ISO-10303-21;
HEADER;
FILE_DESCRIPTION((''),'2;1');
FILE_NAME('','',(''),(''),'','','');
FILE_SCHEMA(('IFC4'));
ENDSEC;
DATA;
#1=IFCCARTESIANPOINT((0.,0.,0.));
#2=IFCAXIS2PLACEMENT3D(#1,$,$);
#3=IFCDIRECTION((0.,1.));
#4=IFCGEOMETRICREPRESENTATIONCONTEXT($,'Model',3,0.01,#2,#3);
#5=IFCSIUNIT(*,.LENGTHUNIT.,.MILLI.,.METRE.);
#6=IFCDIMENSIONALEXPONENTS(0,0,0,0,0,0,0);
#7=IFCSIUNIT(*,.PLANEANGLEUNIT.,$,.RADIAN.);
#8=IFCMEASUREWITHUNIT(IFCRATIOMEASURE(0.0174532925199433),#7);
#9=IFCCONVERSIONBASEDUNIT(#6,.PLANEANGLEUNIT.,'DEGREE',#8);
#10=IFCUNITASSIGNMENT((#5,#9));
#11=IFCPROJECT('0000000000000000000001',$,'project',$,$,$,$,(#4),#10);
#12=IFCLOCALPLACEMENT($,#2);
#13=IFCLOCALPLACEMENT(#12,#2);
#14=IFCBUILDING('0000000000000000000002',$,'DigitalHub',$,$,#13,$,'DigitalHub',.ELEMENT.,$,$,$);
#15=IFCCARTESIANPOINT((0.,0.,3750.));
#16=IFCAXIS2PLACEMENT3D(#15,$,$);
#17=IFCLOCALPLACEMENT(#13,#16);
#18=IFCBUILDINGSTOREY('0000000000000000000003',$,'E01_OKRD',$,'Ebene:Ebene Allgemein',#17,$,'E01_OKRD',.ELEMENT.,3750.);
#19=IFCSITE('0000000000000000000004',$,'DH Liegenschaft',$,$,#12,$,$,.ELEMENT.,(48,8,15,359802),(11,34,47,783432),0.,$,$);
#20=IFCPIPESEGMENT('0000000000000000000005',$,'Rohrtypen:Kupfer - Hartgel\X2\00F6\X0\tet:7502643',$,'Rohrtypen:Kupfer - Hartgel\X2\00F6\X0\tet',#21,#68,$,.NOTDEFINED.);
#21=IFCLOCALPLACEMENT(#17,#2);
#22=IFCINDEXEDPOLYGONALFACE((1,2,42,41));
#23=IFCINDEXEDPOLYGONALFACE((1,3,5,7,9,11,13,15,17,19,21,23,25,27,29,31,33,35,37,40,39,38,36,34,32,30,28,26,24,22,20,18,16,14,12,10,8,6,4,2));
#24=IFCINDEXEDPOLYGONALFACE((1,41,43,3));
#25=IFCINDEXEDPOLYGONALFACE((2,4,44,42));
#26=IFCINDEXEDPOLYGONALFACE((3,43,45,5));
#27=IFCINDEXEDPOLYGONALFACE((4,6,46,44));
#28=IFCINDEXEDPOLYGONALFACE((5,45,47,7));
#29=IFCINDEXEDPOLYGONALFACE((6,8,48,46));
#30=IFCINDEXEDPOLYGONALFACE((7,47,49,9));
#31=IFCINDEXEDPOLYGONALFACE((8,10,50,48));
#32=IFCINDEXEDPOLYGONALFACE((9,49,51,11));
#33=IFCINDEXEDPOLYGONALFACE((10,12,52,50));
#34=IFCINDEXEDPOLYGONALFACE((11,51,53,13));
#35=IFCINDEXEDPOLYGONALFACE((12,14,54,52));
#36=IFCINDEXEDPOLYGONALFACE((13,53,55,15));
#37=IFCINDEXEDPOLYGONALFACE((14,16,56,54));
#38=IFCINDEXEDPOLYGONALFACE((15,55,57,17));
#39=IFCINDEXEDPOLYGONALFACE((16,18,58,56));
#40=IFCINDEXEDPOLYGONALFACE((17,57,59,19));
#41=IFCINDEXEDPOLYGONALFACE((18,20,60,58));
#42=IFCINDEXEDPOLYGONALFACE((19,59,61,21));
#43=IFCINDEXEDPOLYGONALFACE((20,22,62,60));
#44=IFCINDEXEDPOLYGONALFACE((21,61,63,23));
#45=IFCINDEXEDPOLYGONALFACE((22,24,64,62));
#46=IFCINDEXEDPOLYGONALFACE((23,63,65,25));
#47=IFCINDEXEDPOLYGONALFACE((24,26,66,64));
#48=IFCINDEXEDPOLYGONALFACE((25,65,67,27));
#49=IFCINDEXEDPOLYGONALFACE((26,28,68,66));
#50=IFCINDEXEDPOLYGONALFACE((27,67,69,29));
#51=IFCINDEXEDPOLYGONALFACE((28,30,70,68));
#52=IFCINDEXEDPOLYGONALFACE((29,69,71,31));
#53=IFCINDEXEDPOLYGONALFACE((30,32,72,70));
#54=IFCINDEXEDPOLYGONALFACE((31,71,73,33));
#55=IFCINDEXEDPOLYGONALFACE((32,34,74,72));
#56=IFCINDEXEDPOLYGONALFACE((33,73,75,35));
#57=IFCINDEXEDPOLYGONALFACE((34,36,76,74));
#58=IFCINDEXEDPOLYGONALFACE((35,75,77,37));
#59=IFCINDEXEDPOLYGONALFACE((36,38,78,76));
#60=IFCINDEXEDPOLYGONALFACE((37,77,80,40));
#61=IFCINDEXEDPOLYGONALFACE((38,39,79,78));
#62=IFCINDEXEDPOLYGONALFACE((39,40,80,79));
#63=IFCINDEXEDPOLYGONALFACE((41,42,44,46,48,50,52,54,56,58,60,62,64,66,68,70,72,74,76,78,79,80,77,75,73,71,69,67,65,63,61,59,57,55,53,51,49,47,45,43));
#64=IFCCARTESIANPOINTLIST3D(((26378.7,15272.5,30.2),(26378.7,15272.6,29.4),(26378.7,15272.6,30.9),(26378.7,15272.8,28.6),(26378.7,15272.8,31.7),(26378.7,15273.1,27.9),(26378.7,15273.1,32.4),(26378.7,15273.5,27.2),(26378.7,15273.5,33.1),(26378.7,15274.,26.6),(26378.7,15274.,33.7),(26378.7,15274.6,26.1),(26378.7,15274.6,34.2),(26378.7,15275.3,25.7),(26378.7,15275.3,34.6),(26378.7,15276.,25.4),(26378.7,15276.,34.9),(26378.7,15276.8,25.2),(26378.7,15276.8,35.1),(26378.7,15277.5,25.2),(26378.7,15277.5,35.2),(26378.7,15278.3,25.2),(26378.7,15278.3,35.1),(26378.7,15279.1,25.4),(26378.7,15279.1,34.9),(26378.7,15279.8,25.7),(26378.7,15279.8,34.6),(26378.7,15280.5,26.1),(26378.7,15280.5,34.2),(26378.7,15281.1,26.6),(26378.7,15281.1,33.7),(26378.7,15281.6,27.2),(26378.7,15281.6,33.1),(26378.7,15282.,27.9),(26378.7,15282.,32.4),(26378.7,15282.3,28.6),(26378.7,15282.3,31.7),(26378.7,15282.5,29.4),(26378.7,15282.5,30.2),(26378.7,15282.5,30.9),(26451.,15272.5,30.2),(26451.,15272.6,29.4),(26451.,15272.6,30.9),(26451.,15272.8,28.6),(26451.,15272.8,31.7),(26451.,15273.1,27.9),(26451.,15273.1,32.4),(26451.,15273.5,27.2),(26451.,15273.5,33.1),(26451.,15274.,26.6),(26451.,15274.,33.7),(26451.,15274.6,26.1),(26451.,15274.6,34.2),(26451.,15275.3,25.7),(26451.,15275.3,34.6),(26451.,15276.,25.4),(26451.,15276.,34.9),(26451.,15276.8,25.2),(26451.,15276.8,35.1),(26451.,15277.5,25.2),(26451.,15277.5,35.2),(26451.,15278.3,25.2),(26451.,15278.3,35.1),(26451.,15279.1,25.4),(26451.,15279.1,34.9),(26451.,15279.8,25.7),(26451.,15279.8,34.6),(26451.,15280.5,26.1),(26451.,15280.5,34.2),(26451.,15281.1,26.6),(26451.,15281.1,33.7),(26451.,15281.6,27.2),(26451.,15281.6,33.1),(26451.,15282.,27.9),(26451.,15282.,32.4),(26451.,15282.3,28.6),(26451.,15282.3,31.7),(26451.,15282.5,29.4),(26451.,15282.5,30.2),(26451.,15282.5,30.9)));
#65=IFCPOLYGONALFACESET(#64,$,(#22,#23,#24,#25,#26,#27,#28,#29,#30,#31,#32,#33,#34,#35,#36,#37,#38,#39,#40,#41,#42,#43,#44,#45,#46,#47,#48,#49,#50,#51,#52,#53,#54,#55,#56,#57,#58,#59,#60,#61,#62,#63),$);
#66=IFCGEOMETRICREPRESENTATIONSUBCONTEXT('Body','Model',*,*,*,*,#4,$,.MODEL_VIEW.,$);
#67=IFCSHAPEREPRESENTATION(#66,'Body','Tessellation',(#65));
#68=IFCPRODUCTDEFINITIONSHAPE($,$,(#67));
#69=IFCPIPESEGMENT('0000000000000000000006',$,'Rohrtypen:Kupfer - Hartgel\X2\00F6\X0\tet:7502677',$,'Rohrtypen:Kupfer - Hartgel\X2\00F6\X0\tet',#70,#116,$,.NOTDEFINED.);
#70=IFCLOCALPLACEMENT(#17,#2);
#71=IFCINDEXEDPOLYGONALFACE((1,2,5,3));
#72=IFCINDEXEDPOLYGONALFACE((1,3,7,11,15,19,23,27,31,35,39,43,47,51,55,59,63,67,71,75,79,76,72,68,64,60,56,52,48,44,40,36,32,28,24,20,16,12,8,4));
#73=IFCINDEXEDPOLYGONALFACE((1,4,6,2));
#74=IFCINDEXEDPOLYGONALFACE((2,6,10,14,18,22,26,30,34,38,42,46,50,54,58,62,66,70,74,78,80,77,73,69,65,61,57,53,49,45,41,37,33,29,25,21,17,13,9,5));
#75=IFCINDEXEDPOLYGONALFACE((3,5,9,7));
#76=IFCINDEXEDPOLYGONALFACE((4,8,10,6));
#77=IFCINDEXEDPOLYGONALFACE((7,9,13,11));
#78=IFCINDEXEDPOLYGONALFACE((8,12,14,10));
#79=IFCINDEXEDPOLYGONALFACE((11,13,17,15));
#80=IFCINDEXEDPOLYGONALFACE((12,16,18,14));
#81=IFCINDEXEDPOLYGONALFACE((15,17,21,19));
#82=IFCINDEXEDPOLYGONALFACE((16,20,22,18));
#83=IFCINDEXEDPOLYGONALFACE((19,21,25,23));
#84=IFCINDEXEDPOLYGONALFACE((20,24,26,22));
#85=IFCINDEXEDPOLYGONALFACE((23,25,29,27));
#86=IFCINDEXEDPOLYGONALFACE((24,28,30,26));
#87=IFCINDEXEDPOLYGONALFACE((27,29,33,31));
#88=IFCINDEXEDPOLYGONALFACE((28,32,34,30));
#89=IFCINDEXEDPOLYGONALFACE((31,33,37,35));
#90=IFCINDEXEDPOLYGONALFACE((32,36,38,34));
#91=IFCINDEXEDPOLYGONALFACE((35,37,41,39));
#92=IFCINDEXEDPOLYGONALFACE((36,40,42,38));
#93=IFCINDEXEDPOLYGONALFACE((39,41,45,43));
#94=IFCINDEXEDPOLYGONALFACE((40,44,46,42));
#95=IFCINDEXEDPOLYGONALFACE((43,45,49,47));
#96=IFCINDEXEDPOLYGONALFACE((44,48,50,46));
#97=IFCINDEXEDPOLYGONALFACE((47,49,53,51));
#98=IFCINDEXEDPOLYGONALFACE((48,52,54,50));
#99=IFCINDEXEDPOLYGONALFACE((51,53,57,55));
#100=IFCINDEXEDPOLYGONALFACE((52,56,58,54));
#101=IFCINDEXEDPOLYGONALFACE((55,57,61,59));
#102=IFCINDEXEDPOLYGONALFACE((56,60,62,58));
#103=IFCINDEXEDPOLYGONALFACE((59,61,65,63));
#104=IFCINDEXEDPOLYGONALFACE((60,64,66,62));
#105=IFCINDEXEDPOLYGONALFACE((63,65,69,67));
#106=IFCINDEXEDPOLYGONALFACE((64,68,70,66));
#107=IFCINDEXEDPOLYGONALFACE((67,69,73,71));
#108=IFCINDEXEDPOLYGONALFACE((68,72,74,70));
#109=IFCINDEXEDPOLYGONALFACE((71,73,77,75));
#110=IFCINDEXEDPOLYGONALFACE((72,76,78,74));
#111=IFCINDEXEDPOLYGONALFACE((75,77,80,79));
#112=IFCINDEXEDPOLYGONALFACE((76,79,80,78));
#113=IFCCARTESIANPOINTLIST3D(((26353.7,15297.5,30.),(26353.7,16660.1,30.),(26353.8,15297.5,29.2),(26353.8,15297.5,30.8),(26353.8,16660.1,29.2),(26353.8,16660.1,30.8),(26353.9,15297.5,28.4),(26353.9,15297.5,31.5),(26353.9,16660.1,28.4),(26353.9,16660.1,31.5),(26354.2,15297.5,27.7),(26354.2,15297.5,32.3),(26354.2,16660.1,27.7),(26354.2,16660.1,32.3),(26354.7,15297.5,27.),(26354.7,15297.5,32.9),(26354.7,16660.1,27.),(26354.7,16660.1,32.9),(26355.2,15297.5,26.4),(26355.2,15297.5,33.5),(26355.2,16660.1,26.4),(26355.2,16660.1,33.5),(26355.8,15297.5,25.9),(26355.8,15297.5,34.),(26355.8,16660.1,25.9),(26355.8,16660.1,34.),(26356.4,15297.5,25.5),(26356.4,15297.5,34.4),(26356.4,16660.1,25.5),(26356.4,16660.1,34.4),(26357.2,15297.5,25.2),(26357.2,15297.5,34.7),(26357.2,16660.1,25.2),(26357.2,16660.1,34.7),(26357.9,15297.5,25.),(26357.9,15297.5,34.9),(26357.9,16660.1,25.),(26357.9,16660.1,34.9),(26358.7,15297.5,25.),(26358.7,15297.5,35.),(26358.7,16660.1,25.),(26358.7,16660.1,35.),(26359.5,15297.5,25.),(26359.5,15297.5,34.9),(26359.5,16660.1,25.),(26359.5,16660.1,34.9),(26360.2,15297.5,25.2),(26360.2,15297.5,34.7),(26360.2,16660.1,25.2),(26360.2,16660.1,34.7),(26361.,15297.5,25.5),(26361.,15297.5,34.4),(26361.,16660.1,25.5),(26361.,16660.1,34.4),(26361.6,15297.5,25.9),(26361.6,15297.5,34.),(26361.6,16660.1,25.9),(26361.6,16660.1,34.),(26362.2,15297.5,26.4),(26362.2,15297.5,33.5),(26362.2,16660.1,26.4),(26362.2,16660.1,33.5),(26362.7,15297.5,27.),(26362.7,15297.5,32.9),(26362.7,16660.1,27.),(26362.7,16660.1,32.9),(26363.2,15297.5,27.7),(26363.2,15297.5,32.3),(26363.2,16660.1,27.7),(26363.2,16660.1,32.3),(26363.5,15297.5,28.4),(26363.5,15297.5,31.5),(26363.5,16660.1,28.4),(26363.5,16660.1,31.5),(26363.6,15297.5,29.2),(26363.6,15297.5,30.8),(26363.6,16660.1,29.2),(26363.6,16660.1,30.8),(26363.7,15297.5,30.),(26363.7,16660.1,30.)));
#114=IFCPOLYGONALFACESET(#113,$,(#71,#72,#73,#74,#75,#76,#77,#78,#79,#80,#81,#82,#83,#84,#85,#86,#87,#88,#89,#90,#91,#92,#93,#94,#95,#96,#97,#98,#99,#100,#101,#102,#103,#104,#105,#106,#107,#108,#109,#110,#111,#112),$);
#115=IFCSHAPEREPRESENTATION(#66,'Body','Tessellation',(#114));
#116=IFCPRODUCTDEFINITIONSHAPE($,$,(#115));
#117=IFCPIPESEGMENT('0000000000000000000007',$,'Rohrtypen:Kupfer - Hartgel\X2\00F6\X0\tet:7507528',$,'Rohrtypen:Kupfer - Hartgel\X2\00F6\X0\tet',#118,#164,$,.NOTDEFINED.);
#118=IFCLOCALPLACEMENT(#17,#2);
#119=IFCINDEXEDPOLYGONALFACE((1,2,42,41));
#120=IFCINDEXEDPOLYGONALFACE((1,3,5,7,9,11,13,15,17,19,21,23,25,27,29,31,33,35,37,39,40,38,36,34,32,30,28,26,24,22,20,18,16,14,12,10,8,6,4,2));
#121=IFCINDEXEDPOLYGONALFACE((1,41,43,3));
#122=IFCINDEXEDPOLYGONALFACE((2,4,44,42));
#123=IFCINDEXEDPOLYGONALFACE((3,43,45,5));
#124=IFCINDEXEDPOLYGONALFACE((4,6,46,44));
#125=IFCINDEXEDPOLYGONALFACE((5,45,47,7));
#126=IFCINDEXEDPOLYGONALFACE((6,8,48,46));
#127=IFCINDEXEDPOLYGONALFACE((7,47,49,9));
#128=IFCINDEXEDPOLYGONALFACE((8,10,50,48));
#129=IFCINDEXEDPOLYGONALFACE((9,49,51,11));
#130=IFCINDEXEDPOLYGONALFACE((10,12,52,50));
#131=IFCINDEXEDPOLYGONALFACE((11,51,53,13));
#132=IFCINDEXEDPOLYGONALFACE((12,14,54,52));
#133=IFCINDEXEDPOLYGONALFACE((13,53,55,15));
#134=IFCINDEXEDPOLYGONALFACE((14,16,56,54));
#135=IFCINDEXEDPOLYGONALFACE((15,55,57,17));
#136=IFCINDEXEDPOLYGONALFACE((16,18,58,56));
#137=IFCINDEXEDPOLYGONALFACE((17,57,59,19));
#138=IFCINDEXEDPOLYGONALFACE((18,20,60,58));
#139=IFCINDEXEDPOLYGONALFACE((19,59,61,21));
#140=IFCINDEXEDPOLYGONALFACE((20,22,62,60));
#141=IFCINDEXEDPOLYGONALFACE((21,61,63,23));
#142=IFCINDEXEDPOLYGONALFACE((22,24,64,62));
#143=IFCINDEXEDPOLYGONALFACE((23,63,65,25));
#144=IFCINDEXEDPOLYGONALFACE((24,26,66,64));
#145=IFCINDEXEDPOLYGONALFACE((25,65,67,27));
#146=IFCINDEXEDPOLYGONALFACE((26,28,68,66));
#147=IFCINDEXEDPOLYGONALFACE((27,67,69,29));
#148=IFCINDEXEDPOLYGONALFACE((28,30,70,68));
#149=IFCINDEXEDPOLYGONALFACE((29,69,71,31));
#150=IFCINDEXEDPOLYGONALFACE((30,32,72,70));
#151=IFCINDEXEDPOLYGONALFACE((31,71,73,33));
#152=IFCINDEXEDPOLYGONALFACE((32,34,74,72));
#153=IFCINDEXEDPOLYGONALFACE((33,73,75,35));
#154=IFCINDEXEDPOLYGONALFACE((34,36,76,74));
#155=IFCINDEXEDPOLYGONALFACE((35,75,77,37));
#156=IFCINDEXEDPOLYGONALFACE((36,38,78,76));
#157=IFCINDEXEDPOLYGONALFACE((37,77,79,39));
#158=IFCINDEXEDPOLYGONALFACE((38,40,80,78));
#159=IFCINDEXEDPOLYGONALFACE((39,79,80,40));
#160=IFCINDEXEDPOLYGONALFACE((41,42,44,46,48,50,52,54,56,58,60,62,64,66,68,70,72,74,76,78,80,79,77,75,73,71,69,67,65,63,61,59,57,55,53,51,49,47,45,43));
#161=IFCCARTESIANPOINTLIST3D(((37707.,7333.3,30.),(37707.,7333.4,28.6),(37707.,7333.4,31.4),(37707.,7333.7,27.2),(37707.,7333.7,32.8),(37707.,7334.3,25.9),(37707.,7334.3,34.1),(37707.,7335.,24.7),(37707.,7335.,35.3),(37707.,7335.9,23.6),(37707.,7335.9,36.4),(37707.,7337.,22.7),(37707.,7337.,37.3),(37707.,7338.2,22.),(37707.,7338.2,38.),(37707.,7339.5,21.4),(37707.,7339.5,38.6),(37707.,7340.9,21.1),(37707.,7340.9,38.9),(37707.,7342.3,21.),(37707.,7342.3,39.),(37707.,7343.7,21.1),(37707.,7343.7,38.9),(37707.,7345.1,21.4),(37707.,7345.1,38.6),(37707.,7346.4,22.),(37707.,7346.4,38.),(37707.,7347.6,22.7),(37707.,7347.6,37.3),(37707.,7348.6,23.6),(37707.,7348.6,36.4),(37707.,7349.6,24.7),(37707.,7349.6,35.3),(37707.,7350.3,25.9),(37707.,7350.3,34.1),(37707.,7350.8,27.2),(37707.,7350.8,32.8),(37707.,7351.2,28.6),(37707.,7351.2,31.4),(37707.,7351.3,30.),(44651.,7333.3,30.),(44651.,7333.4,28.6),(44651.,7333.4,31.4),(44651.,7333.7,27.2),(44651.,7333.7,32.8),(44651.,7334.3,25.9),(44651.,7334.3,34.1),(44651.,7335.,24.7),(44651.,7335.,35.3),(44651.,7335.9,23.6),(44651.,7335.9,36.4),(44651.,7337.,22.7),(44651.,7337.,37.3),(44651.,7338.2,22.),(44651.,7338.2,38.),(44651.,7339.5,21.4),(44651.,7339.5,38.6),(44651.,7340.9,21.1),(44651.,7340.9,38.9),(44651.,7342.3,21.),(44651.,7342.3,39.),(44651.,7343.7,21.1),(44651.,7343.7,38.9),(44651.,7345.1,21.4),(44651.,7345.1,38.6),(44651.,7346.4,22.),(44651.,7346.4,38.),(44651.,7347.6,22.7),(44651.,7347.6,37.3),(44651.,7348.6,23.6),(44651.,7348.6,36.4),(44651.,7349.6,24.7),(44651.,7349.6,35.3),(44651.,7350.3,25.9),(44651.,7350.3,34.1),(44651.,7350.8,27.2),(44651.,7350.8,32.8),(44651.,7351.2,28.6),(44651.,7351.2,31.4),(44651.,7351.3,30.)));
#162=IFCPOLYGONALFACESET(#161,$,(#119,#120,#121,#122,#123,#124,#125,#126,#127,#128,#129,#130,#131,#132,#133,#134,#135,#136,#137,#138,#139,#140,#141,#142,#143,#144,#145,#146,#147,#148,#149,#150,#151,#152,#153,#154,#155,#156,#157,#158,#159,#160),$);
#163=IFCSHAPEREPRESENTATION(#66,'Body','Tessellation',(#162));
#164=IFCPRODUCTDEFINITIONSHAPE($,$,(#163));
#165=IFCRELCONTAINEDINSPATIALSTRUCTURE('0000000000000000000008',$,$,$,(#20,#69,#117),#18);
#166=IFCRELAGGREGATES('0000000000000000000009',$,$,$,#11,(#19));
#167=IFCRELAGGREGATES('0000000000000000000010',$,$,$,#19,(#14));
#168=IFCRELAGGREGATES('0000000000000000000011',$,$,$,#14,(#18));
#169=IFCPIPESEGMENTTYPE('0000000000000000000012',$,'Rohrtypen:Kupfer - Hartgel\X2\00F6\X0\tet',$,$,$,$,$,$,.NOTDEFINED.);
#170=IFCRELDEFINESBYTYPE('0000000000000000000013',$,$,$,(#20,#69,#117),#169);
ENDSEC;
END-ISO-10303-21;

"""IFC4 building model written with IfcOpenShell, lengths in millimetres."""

from ifc_helpers import new_model, entity, si_unit, converted_unit, direction, frame, origin, place, context, subcontext, project, spatial, indexed_curve, outline, extrude, type_object, element, save


model = new_model("IFC4")

# Units and contexts
model_context = context("Model", 3, precision=0.01, world=origin(), true_north=direction((0.0, 1.0)))
body_context = subcontext(model_context, "Body", "Model", "MODEL_VIEW")
ifc_project = project(units=[si_unit("LENGTHUNIT", "METRE", prefix="MILLI"), converted_unit("PLANEANGLEUNIT", "DEGREE", entity("IfcRatioMeasure", 0.0174532925199433), si_unit("PLANEANGLEUNIT", "RADIAN"), dimensions=[0, 0, 0, 0, 0, 0, 0])], contexts=[model_context])

# Site, building, storey
site_placement = place(None, origin())
site = spatial("IfcSite", under=ifc_project, at=site_placement, Name="DH Liegenschaft", CompositionType="ELEMENT", RefLatitude=(48, 8, 15, 359802), RefLongitude=(11, 34, 47, 783432), RefElevation=0.0)
building_placement = place(site_placement, origin())
building = spatial("IfcBuilding", under=site, at=building_placement, Name="DigitalHub", LongName="DigitalHub", CompositionType="ELEMENT")
storey_placement = place(building_placement, frame((0.0, 0.0, 3750.0)))
storey = spatial("IfcBuildingStorey", under=building, at=storey_placement, Name="E01_OKRD", ObjectType="Ebene:Ebene Allgemein", LongName="E01_OKRD", CompositionType="ELEMENT", Elevation=3750.0)

# Pipe segments
pipe_segment_type = type_object("IfcPipeSegmentType", Name="Rohrtypen:Kupfer - Hartgelötet", PredefinedType="NOTDEFINED")
pipe_segment_1_placement = place(storey_placement, frame((26378.7, 15270.9, 23.6)))
element("IfcPipeSegment", 1, at=pipe_segment_1_placement, inside=storey, type_object=pipe_segment_type, Name="Rohrtypen:Kupfer - Hartgelötet:7502643", ObjectType="Rohrtypen:Kupfer - Hartgelötet", PredefinedType="NOTDEFINED", context=body_context, shape_type="SweptSolid", body=[
    extrude(outline(indexed_curve([(5.0, 0.0), (4.9, 0.8), (4.8, 1.5), (4.5, 2.3), (4.0, 2.9), (3.5, 3.5), (2.9, 4.0), (2.3, 4.5), (1.5, 4.8), (0.8, 4.9), (0.0, 5.0), (-0.8, 4.9), (-1.5, 4.8), (-2.3, 4.5), (-2.9, 4.0), (-3.5, 3.5), (-4.0, 2.9), (-4.5, 2.3), (-4.8, 1.5), (-4.9, 0.8), (-5.0, 0.0), (-4.9, -0.8), (-4.8, -1.5), (-4.5, -2.3), (-4.0, -2.9), (-3.5, -3.5), (-2.9, -4.0), (-2.3, -4.5), (-1.5, -4.8), (-0.8, -4.9), (0.0, -5.0), (0.8, -4.9), (1.5, -4.8), (2.3, -4.5), (2.9, -4.0), (3.5, -3.5), (4.0, -2.9), (4.5, -2.3), (4.8, -1.5), (4.9, -0.8), (5.0, 0.0)], self_intersect=False)), frame((0.0, 6.6, 6.6), z_axis=(1.0, 0.0, 0.0), x_axis=(0.0, 1.0, 0.0)), (0.0, 0.0, 1.0), 72.2),
])
pipe_segment_2_placement = place(storey_placement, frame((26352.1, 15297.5, 23.4)))
element("IfcPipeSegment", 2, at=pipe_segment_2_placement, inside=storey, type_object=pipe_segment_type, Name="Rohrtypen:Kupfer - Hartgelötet:7502677", ObjectType="Rohrtypen:Kupfer - Hartgelötet", PredefinedType="NOTDEFINED", context=body_context, shape_type="SweptSolid", body=[
    extrude(outline(indexed_curve([(5.0, 0.0), (4.9, 0.8), (4.8, 1.5), (4.5, 2.3), (4.0, 2.9), (3.5, 3.5), (2.9, 4.0), (2.3, 4.5), (1.5, 4.8), (0.8, 4.9), (0.0, 5.0), (-0.8, 4.9), (-1.5, 4.8), (-2.3, 4.5), (-2.9, 4.0), (-3.5, 3.5), (-4.0, 2.9), (-4.5, 2.3), (-4.8, 1.5), (-4.9, 0.8), (-5.0, 0.0), (-4.9, -0.8), (-4.8, -1.5), (-4.5, -2.3), (-4.0, -2.9), (-3.5, -3.5), (-2.9, -4.0), (-2.3, -4.5), (-1.5, -4.8), (-0.8, -4.9), (0.0, -5.0), (0.8, -4.9), (1.5, -4.8), (2.3, -4.5), (2.9, -4.0), (3.5, -3.5), (4.0, -2.9), (4.5, -2.3), (4.8, -1.5), (4.9, -0.8), (5.0, 0.0)], self_intersect=False)), frame((6.6, 0.0, 6.6), z_axis=(0.0, 1.0, 0.0), x_axis=(-1.0, 0.0, 0.0)), (0.0, 0.0, 1.0), 1362.6),
])
pipe_segment_3_placement = place(storey_placement, frame((37707.0, 7331.7, 19.4)))
element("IfcPipeSegment", 3, at=pipe_segment_3_placement, inside=storey, type_object=pipe_segment_type, Name="Rohrtypen:Kupfer - Hartgelötet:7507528", ObjectType="Rohrtypen:Kupfer - Hartgelötet", PredefinedType="NOTDEFINED", context=body_context, shape_type="SweptSolid", body=[
    extrude(outline(indexed_curve([(9.0, 0.0), (8.9, 1.4), (8.6, 2.8), (8.0, 4.1), (7.3, 5.3), (6.4, 6.4), (5.3, 7.3), (4.1, 8.0), (2.8, 8.6), (1.4, 8.9), (0.0, 9.0), (-1.4, 8.9), (-2.8, 8.6), (-4.1, 8.0), (-5.3, 7.3), (-6.4, 6.4), (-7.3, 5.3), (-8.0, 4.1), (-8.6, 2.8), (-8.9, 1.4), (-9.0, 0.0), (-8.9, -1.4), (-8.6, -2.8), (-8.0, -4.1), (-7.3, -5.3), (-6.4, -6.4), (-5.3, -7.3), (-4.1, -8.0), (-2.8, -8.6), (-1.4, -8.9), (0.0, -9.0), (1.4, -8.9), (2.8, -8.6), (4.1, -8.0), (5.3, -7.3), (6.4, -6.4), (7.3, -5.3), (8.0, -4.1), (8.6, -2.8), (8.9, -1.4), (9.0, 0.0)], self_intersect=False)), frame((0.0, 10.6, 10.6), z_axis=(1.0, 0.0, 0.0), x_axis=(0.0, 1.0, 0.0)), (0.0, 0.0, 1.0), 6944.0),
])

save(model, "model.ifc")
